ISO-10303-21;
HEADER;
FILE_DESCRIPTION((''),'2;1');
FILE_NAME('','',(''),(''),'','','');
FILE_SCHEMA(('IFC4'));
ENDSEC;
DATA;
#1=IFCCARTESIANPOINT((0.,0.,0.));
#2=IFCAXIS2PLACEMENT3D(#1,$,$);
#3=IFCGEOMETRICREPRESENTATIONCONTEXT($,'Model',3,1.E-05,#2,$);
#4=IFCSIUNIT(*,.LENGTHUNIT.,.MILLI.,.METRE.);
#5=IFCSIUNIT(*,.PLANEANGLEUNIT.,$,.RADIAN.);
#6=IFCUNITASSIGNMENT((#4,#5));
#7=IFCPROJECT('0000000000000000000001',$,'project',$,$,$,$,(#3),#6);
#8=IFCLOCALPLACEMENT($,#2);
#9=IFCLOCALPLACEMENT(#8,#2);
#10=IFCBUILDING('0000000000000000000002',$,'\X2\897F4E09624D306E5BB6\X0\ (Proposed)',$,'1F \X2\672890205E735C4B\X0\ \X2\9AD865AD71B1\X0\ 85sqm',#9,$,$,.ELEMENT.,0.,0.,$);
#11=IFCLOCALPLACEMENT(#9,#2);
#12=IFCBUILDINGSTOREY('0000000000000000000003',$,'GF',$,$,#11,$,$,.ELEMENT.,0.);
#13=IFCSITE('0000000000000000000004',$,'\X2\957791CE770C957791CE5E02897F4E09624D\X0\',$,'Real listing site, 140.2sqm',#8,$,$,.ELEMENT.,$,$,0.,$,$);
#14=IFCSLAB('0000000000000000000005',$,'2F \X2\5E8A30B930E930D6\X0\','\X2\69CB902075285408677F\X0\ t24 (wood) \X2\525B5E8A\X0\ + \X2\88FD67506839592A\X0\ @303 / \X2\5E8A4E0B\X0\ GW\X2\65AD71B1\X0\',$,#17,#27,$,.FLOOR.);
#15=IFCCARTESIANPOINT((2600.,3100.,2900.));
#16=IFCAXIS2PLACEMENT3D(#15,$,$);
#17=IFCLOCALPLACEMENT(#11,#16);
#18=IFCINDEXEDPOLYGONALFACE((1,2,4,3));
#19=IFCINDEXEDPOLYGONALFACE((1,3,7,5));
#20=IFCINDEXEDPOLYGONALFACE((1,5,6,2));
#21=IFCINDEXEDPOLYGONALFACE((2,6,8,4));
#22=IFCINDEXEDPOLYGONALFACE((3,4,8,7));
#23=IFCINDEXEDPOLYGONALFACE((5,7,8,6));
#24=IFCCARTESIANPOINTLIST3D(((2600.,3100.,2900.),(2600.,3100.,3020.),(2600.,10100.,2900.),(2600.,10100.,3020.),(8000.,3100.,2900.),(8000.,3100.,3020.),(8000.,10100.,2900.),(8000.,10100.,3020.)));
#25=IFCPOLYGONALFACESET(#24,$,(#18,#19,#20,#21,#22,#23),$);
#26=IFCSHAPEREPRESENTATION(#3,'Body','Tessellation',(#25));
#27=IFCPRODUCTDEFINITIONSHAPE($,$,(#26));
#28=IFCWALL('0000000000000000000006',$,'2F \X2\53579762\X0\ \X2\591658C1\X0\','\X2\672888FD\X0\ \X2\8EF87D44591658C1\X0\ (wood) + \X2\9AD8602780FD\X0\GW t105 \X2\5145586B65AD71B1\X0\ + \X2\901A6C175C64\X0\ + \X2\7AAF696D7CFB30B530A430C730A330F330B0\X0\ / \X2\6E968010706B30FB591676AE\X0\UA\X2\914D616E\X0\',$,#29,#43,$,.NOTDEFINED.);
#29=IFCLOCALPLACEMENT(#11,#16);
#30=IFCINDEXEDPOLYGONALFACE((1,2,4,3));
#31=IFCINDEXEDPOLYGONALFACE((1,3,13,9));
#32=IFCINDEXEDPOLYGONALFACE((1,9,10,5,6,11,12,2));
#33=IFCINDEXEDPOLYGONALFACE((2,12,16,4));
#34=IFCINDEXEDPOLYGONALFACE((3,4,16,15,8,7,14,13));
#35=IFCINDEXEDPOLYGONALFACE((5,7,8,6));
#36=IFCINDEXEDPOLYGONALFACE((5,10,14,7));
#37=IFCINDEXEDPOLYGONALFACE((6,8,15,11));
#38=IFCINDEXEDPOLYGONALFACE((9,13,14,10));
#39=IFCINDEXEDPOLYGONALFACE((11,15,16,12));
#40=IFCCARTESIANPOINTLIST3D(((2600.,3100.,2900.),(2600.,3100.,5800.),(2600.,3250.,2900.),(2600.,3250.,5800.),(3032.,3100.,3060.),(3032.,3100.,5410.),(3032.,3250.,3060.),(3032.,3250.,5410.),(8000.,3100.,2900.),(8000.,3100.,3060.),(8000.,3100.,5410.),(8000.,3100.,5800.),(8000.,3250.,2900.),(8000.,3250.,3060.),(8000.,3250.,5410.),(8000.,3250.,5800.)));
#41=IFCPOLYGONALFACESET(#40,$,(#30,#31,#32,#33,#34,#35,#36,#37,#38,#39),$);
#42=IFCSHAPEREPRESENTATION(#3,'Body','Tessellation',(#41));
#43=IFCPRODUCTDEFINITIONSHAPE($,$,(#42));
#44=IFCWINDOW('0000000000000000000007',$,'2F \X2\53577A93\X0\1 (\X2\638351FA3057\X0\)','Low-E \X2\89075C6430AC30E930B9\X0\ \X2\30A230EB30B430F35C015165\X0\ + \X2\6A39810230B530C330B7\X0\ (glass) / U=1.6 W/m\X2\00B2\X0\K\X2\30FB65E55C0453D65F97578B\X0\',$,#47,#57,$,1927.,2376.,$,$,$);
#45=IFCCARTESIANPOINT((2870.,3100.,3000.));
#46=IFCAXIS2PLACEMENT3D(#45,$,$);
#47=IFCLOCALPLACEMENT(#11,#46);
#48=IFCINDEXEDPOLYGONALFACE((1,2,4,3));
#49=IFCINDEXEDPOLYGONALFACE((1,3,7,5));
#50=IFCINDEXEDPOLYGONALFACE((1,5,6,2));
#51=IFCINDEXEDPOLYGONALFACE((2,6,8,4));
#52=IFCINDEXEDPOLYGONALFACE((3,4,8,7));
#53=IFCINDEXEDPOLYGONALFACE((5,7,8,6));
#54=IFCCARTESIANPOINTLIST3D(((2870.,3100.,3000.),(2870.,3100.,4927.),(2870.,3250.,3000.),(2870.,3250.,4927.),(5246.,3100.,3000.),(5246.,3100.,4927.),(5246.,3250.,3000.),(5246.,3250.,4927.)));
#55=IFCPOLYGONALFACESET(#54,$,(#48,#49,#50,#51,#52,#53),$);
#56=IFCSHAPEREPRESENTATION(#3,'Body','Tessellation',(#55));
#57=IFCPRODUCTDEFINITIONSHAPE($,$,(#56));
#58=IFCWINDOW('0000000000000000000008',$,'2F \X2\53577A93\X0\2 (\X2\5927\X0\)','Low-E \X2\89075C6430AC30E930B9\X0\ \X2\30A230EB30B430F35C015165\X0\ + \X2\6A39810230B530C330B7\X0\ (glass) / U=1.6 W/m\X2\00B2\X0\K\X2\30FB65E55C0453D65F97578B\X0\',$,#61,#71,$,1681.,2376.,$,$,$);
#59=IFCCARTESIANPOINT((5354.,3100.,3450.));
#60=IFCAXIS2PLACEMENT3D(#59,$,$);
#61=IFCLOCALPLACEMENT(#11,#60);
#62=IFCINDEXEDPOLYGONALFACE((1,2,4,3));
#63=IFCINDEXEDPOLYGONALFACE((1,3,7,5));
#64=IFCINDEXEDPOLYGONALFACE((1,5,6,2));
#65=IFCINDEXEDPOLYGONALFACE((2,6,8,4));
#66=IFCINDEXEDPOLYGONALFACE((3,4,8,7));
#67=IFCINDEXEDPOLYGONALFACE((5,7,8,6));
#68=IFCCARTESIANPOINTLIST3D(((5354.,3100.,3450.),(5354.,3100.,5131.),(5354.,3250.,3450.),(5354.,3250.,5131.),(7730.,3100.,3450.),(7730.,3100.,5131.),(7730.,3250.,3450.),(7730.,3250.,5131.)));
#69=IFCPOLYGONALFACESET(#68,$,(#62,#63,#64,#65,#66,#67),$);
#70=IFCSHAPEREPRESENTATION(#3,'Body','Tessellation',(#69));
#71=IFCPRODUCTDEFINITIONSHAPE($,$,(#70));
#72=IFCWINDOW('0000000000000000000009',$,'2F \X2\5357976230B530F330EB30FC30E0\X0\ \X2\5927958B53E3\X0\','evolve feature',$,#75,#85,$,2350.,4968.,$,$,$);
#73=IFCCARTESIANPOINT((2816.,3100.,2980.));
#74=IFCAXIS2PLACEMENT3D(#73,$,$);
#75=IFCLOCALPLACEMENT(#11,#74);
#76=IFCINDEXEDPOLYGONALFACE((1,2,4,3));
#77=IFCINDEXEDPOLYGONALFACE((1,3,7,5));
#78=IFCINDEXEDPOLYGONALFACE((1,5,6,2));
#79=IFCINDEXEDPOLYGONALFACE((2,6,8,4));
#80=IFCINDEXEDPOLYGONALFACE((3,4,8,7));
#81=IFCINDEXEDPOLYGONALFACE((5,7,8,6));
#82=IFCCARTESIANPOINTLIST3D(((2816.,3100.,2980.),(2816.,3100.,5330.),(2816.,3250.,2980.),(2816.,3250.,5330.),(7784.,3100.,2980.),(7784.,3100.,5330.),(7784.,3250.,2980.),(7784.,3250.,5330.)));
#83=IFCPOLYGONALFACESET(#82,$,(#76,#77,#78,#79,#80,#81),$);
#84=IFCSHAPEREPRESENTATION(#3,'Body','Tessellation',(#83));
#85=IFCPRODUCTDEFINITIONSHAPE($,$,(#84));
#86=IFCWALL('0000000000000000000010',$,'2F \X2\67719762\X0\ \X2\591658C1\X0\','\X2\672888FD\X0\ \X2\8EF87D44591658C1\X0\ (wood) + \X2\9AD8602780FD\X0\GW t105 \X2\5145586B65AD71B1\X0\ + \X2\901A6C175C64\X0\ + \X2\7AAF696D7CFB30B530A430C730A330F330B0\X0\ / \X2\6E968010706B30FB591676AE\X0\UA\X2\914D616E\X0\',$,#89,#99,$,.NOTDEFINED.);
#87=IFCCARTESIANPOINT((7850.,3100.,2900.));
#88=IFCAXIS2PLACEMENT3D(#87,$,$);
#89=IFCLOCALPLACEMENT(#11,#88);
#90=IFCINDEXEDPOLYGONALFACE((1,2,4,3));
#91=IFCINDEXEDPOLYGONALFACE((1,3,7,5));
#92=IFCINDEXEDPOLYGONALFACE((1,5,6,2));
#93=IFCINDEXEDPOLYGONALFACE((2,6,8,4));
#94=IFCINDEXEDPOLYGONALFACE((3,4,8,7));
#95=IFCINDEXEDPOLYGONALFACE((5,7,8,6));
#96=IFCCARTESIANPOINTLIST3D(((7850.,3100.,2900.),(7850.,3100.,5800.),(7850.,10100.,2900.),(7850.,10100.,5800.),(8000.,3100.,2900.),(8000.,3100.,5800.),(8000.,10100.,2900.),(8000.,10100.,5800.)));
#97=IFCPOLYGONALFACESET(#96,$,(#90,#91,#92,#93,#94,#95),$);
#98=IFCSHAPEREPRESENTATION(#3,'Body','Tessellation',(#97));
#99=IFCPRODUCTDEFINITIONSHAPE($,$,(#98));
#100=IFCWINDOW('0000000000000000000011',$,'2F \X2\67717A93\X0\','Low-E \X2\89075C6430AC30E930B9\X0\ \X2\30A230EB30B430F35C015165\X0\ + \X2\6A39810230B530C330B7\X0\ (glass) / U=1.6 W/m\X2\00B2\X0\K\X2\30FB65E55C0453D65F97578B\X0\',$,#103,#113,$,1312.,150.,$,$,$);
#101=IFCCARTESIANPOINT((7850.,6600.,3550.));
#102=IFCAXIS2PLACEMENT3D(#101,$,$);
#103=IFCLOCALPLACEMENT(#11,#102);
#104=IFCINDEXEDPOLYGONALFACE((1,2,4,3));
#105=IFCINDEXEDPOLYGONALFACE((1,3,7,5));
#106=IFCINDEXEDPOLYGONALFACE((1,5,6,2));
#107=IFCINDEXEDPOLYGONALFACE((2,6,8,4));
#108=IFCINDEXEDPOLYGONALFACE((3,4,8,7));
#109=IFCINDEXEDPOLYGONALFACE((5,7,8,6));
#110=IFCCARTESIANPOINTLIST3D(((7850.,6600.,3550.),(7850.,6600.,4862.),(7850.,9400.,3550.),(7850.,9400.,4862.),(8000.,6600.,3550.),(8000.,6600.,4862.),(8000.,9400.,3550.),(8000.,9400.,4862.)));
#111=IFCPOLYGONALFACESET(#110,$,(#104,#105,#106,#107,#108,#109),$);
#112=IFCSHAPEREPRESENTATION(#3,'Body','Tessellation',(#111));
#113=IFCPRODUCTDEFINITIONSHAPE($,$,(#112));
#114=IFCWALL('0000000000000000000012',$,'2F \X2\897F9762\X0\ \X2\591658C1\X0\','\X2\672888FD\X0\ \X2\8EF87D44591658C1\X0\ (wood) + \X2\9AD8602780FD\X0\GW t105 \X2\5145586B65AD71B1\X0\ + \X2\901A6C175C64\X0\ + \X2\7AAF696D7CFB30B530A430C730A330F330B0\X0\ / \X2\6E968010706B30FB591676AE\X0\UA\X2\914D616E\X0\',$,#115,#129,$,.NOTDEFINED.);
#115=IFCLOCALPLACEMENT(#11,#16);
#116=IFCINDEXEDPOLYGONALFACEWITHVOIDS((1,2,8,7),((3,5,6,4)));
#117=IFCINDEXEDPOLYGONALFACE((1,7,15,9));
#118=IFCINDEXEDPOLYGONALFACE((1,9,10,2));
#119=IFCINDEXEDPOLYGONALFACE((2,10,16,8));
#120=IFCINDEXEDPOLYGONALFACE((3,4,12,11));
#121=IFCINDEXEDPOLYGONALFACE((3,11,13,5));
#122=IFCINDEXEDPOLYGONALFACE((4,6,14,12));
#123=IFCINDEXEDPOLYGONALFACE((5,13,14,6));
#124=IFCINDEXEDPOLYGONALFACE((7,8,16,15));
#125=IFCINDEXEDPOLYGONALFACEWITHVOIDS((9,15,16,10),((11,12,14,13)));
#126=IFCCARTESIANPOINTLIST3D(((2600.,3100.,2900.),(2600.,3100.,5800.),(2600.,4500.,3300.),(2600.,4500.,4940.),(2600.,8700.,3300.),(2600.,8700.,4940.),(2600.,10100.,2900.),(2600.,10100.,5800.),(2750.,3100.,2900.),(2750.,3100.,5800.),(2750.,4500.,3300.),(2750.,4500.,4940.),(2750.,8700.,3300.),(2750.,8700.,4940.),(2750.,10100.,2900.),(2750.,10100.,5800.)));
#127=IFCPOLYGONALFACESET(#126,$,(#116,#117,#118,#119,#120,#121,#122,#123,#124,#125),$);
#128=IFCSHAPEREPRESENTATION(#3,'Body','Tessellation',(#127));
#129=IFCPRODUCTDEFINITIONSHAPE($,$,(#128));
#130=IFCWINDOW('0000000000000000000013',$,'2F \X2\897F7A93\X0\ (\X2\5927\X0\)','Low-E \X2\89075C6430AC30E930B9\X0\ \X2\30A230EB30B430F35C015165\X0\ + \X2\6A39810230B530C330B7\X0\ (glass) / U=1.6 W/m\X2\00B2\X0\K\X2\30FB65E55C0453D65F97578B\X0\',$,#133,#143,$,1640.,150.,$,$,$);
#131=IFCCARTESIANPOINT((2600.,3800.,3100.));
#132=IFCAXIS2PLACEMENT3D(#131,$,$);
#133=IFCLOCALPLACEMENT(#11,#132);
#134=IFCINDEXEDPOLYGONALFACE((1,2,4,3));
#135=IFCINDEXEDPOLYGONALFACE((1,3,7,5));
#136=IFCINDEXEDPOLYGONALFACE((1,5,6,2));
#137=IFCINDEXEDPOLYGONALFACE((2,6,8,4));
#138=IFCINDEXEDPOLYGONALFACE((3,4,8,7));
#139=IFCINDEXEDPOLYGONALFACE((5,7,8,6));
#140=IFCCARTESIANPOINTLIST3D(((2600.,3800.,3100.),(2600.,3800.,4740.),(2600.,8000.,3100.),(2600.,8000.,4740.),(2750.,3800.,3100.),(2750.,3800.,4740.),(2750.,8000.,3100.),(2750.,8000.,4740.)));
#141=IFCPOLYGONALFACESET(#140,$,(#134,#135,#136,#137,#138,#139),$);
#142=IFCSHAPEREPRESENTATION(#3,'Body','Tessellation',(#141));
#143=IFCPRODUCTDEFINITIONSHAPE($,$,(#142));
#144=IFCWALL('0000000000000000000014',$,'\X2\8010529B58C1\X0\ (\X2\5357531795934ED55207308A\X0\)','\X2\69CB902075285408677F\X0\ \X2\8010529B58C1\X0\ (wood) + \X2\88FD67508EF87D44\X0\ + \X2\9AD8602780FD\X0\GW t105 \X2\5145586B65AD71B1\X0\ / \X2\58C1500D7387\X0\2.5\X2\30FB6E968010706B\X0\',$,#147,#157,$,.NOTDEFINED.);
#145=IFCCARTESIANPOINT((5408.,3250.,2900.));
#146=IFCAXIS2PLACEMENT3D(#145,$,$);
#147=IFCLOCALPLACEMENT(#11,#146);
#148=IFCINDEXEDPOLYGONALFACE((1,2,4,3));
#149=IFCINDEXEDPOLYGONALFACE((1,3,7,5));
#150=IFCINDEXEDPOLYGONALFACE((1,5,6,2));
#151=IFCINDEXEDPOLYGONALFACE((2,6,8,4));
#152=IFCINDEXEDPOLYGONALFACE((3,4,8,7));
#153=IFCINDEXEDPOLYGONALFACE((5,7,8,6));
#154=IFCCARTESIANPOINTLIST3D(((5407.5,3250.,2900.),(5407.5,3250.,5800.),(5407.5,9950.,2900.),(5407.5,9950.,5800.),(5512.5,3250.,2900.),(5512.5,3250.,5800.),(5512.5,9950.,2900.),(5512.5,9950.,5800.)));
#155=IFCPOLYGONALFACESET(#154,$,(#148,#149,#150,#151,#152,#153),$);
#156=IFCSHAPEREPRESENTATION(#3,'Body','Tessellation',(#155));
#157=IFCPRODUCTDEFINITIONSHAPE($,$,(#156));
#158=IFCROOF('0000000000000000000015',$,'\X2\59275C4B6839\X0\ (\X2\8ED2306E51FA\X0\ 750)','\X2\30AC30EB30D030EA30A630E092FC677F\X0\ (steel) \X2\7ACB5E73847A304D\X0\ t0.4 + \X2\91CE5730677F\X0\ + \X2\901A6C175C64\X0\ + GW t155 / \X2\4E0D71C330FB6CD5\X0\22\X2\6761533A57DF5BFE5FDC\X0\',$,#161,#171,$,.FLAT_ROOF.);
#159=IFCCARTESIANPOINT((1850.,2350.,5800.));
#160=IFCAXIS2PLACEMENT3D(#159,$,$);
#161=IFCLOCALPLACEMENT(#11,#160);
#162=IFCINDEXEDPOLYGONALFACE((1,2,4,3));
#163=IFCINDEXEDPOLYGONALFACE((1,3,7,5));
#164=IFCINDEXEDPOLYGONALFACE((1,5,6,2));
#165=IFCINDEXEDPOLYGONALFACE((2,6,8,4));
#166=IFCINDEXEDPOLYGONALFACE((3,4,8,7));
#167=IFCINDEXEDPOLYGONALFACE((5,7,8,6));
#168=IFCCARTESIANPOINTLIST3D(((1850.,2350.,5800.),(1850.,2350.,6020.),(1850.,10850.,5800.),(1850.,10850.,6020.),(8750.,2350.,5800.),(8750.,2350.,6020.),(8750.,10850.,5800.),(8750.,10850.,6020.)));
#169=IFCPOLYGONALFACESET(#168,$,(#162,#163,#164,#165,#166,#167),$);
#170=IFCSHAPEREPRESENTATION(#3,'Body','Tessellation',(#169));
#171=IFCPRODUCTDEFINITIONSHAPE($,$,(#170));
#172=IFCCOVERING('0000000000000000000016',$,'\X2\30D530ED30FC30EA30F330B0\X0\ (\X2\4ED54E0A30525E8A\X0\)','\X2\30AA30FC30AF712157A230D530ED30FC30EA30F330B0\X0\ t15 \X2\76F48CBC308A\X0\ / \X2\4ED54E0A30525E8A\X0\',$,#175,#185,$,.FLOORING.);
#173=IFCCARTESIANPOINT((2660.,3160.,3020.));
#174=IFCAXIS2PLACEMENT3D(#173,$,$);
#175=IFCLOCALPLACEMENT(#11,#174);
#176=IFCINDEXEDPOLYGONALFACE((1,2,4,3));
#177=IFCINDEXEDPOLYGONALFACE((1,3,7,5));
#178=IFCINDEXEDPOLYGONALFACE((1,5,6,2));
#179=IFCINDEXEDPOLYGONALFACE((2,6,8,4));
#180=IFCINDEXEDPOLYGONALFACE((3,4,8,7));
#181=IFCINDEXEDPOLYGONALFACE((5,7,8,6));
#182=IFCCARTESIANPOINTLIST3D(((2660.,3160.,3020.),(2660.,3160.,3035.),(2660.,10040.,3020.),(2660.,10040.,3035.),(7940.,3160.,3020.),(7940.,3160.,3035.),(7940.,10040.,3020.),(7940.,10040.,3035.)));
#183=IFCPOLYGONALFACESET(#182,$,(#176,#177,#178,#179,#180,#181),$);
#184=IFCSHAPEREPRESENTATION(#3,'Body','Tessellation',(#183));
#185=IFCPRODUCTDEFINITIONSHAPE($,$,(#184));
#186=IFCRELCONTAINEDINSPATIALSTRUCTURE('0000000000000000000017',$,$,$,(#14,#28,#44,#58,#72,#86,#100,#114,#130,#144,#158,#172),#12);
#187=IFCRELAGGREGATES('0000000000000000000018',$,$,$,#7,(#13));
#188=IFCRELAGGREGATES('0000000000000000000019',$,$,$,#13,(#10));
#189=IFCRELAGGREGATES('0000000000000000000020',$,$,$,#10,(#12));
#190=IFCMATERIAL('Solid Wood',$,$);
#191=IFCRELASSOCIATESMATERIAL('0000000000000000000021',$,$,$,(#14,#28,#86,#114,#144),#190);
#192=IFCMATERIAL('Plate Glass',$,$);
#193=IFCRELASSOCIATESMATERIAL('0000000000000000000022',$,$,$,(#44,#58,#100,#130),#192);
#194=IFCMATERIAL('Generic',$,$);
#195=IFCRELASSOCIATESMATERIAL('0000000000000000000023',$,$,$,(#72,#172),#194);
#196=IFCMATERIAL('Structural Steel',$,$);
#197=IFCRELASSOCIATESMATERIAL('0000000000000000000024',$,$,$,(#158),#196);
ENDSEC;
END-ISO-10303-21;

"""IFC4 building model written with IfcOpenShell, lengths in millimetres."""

from ifc_helpers import new_model, si_unit, frame, frame_2d, origin, place, context, project, spatial, rectangle, extrude, material, element, fill, save


model = new_model("IFC4")

# Units and contexts
model_context = context("Model", 3, precision=1e-05, world=origin())
ifc_project = project(units=[si_unit("LENGTHUNIT", "METRE", prefix="MILLI"), si_unit("PLANEANGLEUNIT", "RADIAN")], contexts=[model_context])

# Site, building, storey
site_placement = place(None, origin())
site = spatial("IfcSite", under=ifc_project, at=site_placement, Name="長野県長野市西三才", ObjectType="Real listing site, 140.2sqm", CompositionType="ELEMENT", RefElevation=0.0)
building_placement = place(site_placement, origin())
building = spatial("IfcBuilding", under=site, at=building_placement, Name="西三才の家 (Proposed)", ObjectType="1F 木造平屋 高断熱 85sqm", CompositionType="ELEMENT", ElevationOfRefHeight=0.0, ElevationOfTerrain=0.0)
storey_placement = place(building_placement, origin())
storey = spatial("IfcBuildingStorey", under=building, at=storey_placement, Name="GF", CompositionType="ELEMENT", Elevation=0.0)

# Slab
ifc_material_1 = material(Name="Solid Wood")
slab_placement = place(storey_placement, frame((2600.0, 3100.0, 2900.0)))
element("IfcSlab", 1, at=slab_placement, inside=storey, material=ifc_material_1, Name="2F 床スラブ", Description="構造用合板 t24 (wood) 剛床 + 製材根太 @303 / 床下 GW断熱", PredefinedType="FLOOR", context=model_context, shape_type="SweptSolid", body=[
    extrude(rectangle(XDim=5400.0, YDim=7000.0, at=frame_2d((2700.0, 3500.0))), frame((2600.0, 3100.0, 2900.0)), (0.0, 0.0, 1.0), 120.0),
])

# Wall, openings, windows
wall_1_placement = place(storey_placement, frame((2600.0, 3100.0, 2900.0)))
wall_1 = element("IfcWall", 2, at=wall_1_placement, inside=storey, material=ifc_material_1, Name="2F 南面 外壁", Description="木製 軸組外壁 (wood) + 高性能GW t105 充填断熱 + 通気層 + 窯業系サイディング / 準耐火・外皮UA配慮", PredefinedType="NOTDEFINED", context=model_context, shape_type="SweptSolid", body=[
    extrude(rectangle(XDim=5400.0, YDim=150.0, at=frame_2d((2700.0, 75.0))), frame((2600.0, 3100.0, 2900.0)), (0.0, 0.0, 1.0), 2900.0),
])
opening_1_placement = place(storey_placement, frame((2870.0, 3100.0, 3000.0)))
opening_1 = element("IfcOpeningElement", 3, at=opening_1_placement, cuts=wall_1, PredefinedType="NOTDEFINED", context=model_context, shape_type="SweptSolid", body=[
    extrude(rectangle(XDim=2376.0, YDim=150.0, at=frame_2d((1188.0, 75.0))), frame((2870.0, 3100.0, 3000.0)), (0.0, 0.0, 1.0), 1927.0),
])
opening_2_placement = place(storey_placement, frame((5354.0, 3100.0, 3450.0)))
opening_2 = element("IfcOpeningElement", 4, at=opening_2_placement, cuts=wall_1, PredefinedType="NOTDEFINED", context=model_context, shape_type="SweptSolid", body=[
    extrude(rectangle(XDim=2376.0, YDim=150.0, at=frame_2d((1188.0, 75.0))), frame((5354.0, 3100.0, 3450.0)), (0.0, 0.0, 1.0), 1681.0),
])
opening_3_placement = place(storey_placement, frame((2816.0, 3100.0, 2980.0)))
opening_3 = element("IfcOpeningElement", 5, at=opening_3_placement, cuts=wall_1, PredefinedType="NOTDEFINED", context=model_context, shape_type="SweptSolid", body=[
    extrude(rectangle(XDim=4968.0, YDim=150.0, at=frame_2d((2484.0, 75.0))), frame((2816.0, 3100.0, 2980.0)), (0.0, 0.0, 1.0), 2350.0),
])
ifc_material_2 = material(Name="Plate Glass")
window_1_placement = place(storey_placement, frame((2870.0, 3100.0, 3000.0)))
window_1 = element("IfcWindow", 6, at=window_1_placement, inside=storey, material=ifc_material_2, Name="2F 南窓1 (掃出し)", Description="Low-E 複層ガラス アルゴン封入 + 樹脂サッシ (glass) / U=1.6 W/m²K・日射取得型", OverallHeight=1927.0, OverallWidth=2376.0, context=model_context, shape_type="SweptSolid", body=[
    extrude(rectangle(XDim=2376.0, YDim=150.0, at=frame_2d((1188.0, 75.0))), frame((2870.0, 3100.0, 3000.0)), (0.0, 0.0, 1.0), 1927.0),
])
fill(opening_1, window_1)
window_2_placement = place(storey_placement, frame((5354.0, 3100.0, 3450.0)))
window_2 = element("IfcWindow", 7, at=window_2_placement, inside=storey, material=ifc_material_2, Name="2F 南窓2 (大)", Description="Low-E 複層ガラス アルゴン封入 + 樹脂サッシ (glass) / U=1.6 W/m²K・日射取得型", OverallHeight=1681.0, OverallWidth=2376.0, context=model_context, shape_type="SweptSolid", body=[
    extrude(rectangle(XDim=2376.0, YDim=150.0, at=frame_2d((1188.0, 75.0))), frame((5354.0, 3100.0, 3450.0)), (0.0, 0.0, 1.0), 1681.0),
])
fill(opening_2, window_2)
ifc_material_3 = material(Name="Generic")
window_3_placement = place(storey_placement, frame((2816.0, 3100.0, 2980.0)))
window_3 = element("IfcWindow", 8, at=window_3_placement, inside=storey, material=ifc_material_3, Name="2F 南面サンルーム 大開口", Description="evolve feature", OverallHeight=2350.0, OverallWidth=4968.0, context=model_context, shape_type="SweptSolid", body=[
    extrude(rectangle(XDim=4968.0, YDim=150.0, at=frame_2d((2484.0, 75.0))), frame((2816.0, 3100.0, 2980.0)), (0.0, 0.0, 1.0), 2350.0),
])
fill(opening_3, window_3)

# Walls, openings, windows
wall_2_placement = place(storey_placement, frame((7850.0, 3100.0, 2900.0)))
wall_2 = element("IfcWall", 9, at=wall_2_placement, inside=storey, material=ifc_material_1, Name="2F 東面 外壁", Description="木製 軸組外壁 (wood) + 高性能GW t105 充填断熱 + 通気層 + 窯業系サイディング / 準耐火・外皮UA配慮", PredefinedType="NOTDEFINED", context=model_context, shape_type="SweptSolid", body=[
    extrude(rectangle(XDim=150.0, YDim=7000.0, at=frame_2d((75.0, 3500.0))), frame((7850.0, 3100.0, 2900.0)), (0.0, 0.0, 1.0), 2900.0),
])
opening_4_placement = place(storey_placement, frame((7850.0, 6600.0, 3550.0)))
opening_4 = element("IfcOpeningElement", 10, at=opening_4_placement, cuts=wall_2, PredefinedType="NOTDEFINED", context=model_context, shape_type="SweptSolid", body=[
    extrude(rectangle(XDim=150.0, YDim=2800.0, at=frame_2d((75.0, 1400.0))), frame((7850.0, 6600.0, 3550.0)), (0.0, 0.0, 1.0), 1312.0),
])
window_4_placement = place(storey_placement, frame((7850.0, 6600.0, 3550.0)))
window_4 = element("IfcWindow", 11, at=window_4_placement, inside=storey, material=ifc_material_2, Name="2F 東窓", Description="Low-E 複層ガラス アルゴン封入 + 樹脂サッシ (glass) / U=1.6 W/m²K・日射取得型", OverallHeight=1312.0, OverallWidth=150.0, context=model_context, shape_type="SweptSolid", body=[
    extrude(rectangle(XDim=150.0, YDim=2800.0, at=frame_2d((75.0, 1400.0))), frame((7850.0, 6600.0, 3550.0)), (0.0, 0.0, 1.0), 1312.0),
])
fill(opening_4, window_4)
wall_3_placement = place(storey_placement, frame((2600.0, 3100.0, 2900.0)))
wall_3 = element("IfcWall", 12, at=wall_3_placement, inside=storey, material=ifc_material_1, Name="2F 西面 外壁", Description="木製 軸組外壁 (wood) + 高性能GW t105 充填断熱 + 通気層 + 窯業系サイディング / 準耐火・外皮UA配慮", PredefinedType="NOTDEFINED", context=model_context, shape_type="SweptSolid", body=[
    extrude(rectangle(XDim=150.0, YDim=7000.0, at=frame_2d((75.0, 3500.0))), frame((2600.0, 3100.0, 2900.0)), (0.0, 0.0, 1.0), 2900.0),
])
opening_5_placement = place(storey_placement, frame((2600.0, 3800.0, 3100.0)))
opening_5 = element("IfcOpeningElement", 13, at=opening_5_placement, cuts=wall_3, PredefinedType="NOTDEFINED", context=model_context, shape_type="SweptSolid", body=[
    extrude(rectangle(XDim=150.0, YDim=4200.0, at=frame_2d((75.0, 2100.0))), frame((2600.0, 3800.0, 3100.0)), (0.0, 0.0, 1.0), 1640.0),
])
window_5_placement = place(storey_placement, frame((2600.0, 3800.0, 3100.0)))
window_5 = element("IfcWindow", 14, at=window_5_placement, inside=storey, material=ifc_material_2, Name="2F 西窓 (大)", Description="Low-E 複層ガラス アルゴン封入 + 樹脂サッシ (glass) / U=1.6 W/m²K・日射取得型", OverallHeight=1640.0, OverallWidth=150.0, context=model_context, shape_type="SweptSolid", body=[
    extrude(rectangle(XDim=150.0, YDim=4200.0, at=frame_2d((75.0, 2100.0))), frame((2600.0, 3800.0, 3100.0)), (0.0, 0.0, 1.0), 1640.0),
])
fill(opening_5, window_5)

# Wall
wall_4_placement = place(storey_placement, frame((5408.0, 3250.0, 2900.0)))
element("IfcWall", 15, at=wall_4_placement, inside=storey, material=ifc_material_1, Name="耐力壁 (南北間仕切り)", Description="構造用合板 耐力壁 (wood) + 製材軸組 + 高性能GW t105 充填断熱 / 壁倍率2.5・準耐火", PredefinedType="NOTDEFINED", context=model_context, shape_type="SweptSolid", body=[
    extrude(rectangle(XDim=105.0, YDim=6700.0, at=frame_2d((52.0, 3350.0))), frame((5408.0, 3250.0, 2900.0)), (0.0, 0.0, 1.0), 2900.0),
])

# Roof
ifc_material_4 = material(Name="Structural Steel")
roof_placement = place(storey_placement, frame((1850.0, 2350.0, 5800.0)))
element("IfcRoof", 16, at=roof_placement, inside=storey, material=ifc_material_4, Name="大屋根 (軒の出 750)", Description="ガルバリウム鋼板 (steel) 立平葺き t0.4 + 野地板 + 通気層 + GW t155 / 不燃・法22条区域対応", PredefinedType="FLAT_ROOF", context=model_context, shape_type="SweptSolid", body=[
    extrude(rectangle(XDim=6900.0, YDim=8500.0, at=frame_2d((3450.0, 4250.0))), frame((1850.0, 2350.0, 5800.0)), (0.0, 0.0, 1.0), 220.0),
])

# Covering
covering_placement = place(storey_placement, frame((2660.0, 3160.0, 3020.0)))
element("IfcCovering", 17, at=covering_placement, inside=storey, material=ifc_material_3, Name="フローリング (仕上げ床)", Description="オーク無垢フローリング t15 直貼り / 仕上げ床", PredefinedType="FLOORING", context=model_context, shape_type="SweptSolid", body=[
    extrude(rectangle(XDim=5280.0, YDim=6880.0, at=frame_2d((2640.0, 3440.0))), frame((2660.0, 3160.0, 3020.0)), (0.0, 0.0, 1.0), 15.0),
])

save(model, "model.ifc")
